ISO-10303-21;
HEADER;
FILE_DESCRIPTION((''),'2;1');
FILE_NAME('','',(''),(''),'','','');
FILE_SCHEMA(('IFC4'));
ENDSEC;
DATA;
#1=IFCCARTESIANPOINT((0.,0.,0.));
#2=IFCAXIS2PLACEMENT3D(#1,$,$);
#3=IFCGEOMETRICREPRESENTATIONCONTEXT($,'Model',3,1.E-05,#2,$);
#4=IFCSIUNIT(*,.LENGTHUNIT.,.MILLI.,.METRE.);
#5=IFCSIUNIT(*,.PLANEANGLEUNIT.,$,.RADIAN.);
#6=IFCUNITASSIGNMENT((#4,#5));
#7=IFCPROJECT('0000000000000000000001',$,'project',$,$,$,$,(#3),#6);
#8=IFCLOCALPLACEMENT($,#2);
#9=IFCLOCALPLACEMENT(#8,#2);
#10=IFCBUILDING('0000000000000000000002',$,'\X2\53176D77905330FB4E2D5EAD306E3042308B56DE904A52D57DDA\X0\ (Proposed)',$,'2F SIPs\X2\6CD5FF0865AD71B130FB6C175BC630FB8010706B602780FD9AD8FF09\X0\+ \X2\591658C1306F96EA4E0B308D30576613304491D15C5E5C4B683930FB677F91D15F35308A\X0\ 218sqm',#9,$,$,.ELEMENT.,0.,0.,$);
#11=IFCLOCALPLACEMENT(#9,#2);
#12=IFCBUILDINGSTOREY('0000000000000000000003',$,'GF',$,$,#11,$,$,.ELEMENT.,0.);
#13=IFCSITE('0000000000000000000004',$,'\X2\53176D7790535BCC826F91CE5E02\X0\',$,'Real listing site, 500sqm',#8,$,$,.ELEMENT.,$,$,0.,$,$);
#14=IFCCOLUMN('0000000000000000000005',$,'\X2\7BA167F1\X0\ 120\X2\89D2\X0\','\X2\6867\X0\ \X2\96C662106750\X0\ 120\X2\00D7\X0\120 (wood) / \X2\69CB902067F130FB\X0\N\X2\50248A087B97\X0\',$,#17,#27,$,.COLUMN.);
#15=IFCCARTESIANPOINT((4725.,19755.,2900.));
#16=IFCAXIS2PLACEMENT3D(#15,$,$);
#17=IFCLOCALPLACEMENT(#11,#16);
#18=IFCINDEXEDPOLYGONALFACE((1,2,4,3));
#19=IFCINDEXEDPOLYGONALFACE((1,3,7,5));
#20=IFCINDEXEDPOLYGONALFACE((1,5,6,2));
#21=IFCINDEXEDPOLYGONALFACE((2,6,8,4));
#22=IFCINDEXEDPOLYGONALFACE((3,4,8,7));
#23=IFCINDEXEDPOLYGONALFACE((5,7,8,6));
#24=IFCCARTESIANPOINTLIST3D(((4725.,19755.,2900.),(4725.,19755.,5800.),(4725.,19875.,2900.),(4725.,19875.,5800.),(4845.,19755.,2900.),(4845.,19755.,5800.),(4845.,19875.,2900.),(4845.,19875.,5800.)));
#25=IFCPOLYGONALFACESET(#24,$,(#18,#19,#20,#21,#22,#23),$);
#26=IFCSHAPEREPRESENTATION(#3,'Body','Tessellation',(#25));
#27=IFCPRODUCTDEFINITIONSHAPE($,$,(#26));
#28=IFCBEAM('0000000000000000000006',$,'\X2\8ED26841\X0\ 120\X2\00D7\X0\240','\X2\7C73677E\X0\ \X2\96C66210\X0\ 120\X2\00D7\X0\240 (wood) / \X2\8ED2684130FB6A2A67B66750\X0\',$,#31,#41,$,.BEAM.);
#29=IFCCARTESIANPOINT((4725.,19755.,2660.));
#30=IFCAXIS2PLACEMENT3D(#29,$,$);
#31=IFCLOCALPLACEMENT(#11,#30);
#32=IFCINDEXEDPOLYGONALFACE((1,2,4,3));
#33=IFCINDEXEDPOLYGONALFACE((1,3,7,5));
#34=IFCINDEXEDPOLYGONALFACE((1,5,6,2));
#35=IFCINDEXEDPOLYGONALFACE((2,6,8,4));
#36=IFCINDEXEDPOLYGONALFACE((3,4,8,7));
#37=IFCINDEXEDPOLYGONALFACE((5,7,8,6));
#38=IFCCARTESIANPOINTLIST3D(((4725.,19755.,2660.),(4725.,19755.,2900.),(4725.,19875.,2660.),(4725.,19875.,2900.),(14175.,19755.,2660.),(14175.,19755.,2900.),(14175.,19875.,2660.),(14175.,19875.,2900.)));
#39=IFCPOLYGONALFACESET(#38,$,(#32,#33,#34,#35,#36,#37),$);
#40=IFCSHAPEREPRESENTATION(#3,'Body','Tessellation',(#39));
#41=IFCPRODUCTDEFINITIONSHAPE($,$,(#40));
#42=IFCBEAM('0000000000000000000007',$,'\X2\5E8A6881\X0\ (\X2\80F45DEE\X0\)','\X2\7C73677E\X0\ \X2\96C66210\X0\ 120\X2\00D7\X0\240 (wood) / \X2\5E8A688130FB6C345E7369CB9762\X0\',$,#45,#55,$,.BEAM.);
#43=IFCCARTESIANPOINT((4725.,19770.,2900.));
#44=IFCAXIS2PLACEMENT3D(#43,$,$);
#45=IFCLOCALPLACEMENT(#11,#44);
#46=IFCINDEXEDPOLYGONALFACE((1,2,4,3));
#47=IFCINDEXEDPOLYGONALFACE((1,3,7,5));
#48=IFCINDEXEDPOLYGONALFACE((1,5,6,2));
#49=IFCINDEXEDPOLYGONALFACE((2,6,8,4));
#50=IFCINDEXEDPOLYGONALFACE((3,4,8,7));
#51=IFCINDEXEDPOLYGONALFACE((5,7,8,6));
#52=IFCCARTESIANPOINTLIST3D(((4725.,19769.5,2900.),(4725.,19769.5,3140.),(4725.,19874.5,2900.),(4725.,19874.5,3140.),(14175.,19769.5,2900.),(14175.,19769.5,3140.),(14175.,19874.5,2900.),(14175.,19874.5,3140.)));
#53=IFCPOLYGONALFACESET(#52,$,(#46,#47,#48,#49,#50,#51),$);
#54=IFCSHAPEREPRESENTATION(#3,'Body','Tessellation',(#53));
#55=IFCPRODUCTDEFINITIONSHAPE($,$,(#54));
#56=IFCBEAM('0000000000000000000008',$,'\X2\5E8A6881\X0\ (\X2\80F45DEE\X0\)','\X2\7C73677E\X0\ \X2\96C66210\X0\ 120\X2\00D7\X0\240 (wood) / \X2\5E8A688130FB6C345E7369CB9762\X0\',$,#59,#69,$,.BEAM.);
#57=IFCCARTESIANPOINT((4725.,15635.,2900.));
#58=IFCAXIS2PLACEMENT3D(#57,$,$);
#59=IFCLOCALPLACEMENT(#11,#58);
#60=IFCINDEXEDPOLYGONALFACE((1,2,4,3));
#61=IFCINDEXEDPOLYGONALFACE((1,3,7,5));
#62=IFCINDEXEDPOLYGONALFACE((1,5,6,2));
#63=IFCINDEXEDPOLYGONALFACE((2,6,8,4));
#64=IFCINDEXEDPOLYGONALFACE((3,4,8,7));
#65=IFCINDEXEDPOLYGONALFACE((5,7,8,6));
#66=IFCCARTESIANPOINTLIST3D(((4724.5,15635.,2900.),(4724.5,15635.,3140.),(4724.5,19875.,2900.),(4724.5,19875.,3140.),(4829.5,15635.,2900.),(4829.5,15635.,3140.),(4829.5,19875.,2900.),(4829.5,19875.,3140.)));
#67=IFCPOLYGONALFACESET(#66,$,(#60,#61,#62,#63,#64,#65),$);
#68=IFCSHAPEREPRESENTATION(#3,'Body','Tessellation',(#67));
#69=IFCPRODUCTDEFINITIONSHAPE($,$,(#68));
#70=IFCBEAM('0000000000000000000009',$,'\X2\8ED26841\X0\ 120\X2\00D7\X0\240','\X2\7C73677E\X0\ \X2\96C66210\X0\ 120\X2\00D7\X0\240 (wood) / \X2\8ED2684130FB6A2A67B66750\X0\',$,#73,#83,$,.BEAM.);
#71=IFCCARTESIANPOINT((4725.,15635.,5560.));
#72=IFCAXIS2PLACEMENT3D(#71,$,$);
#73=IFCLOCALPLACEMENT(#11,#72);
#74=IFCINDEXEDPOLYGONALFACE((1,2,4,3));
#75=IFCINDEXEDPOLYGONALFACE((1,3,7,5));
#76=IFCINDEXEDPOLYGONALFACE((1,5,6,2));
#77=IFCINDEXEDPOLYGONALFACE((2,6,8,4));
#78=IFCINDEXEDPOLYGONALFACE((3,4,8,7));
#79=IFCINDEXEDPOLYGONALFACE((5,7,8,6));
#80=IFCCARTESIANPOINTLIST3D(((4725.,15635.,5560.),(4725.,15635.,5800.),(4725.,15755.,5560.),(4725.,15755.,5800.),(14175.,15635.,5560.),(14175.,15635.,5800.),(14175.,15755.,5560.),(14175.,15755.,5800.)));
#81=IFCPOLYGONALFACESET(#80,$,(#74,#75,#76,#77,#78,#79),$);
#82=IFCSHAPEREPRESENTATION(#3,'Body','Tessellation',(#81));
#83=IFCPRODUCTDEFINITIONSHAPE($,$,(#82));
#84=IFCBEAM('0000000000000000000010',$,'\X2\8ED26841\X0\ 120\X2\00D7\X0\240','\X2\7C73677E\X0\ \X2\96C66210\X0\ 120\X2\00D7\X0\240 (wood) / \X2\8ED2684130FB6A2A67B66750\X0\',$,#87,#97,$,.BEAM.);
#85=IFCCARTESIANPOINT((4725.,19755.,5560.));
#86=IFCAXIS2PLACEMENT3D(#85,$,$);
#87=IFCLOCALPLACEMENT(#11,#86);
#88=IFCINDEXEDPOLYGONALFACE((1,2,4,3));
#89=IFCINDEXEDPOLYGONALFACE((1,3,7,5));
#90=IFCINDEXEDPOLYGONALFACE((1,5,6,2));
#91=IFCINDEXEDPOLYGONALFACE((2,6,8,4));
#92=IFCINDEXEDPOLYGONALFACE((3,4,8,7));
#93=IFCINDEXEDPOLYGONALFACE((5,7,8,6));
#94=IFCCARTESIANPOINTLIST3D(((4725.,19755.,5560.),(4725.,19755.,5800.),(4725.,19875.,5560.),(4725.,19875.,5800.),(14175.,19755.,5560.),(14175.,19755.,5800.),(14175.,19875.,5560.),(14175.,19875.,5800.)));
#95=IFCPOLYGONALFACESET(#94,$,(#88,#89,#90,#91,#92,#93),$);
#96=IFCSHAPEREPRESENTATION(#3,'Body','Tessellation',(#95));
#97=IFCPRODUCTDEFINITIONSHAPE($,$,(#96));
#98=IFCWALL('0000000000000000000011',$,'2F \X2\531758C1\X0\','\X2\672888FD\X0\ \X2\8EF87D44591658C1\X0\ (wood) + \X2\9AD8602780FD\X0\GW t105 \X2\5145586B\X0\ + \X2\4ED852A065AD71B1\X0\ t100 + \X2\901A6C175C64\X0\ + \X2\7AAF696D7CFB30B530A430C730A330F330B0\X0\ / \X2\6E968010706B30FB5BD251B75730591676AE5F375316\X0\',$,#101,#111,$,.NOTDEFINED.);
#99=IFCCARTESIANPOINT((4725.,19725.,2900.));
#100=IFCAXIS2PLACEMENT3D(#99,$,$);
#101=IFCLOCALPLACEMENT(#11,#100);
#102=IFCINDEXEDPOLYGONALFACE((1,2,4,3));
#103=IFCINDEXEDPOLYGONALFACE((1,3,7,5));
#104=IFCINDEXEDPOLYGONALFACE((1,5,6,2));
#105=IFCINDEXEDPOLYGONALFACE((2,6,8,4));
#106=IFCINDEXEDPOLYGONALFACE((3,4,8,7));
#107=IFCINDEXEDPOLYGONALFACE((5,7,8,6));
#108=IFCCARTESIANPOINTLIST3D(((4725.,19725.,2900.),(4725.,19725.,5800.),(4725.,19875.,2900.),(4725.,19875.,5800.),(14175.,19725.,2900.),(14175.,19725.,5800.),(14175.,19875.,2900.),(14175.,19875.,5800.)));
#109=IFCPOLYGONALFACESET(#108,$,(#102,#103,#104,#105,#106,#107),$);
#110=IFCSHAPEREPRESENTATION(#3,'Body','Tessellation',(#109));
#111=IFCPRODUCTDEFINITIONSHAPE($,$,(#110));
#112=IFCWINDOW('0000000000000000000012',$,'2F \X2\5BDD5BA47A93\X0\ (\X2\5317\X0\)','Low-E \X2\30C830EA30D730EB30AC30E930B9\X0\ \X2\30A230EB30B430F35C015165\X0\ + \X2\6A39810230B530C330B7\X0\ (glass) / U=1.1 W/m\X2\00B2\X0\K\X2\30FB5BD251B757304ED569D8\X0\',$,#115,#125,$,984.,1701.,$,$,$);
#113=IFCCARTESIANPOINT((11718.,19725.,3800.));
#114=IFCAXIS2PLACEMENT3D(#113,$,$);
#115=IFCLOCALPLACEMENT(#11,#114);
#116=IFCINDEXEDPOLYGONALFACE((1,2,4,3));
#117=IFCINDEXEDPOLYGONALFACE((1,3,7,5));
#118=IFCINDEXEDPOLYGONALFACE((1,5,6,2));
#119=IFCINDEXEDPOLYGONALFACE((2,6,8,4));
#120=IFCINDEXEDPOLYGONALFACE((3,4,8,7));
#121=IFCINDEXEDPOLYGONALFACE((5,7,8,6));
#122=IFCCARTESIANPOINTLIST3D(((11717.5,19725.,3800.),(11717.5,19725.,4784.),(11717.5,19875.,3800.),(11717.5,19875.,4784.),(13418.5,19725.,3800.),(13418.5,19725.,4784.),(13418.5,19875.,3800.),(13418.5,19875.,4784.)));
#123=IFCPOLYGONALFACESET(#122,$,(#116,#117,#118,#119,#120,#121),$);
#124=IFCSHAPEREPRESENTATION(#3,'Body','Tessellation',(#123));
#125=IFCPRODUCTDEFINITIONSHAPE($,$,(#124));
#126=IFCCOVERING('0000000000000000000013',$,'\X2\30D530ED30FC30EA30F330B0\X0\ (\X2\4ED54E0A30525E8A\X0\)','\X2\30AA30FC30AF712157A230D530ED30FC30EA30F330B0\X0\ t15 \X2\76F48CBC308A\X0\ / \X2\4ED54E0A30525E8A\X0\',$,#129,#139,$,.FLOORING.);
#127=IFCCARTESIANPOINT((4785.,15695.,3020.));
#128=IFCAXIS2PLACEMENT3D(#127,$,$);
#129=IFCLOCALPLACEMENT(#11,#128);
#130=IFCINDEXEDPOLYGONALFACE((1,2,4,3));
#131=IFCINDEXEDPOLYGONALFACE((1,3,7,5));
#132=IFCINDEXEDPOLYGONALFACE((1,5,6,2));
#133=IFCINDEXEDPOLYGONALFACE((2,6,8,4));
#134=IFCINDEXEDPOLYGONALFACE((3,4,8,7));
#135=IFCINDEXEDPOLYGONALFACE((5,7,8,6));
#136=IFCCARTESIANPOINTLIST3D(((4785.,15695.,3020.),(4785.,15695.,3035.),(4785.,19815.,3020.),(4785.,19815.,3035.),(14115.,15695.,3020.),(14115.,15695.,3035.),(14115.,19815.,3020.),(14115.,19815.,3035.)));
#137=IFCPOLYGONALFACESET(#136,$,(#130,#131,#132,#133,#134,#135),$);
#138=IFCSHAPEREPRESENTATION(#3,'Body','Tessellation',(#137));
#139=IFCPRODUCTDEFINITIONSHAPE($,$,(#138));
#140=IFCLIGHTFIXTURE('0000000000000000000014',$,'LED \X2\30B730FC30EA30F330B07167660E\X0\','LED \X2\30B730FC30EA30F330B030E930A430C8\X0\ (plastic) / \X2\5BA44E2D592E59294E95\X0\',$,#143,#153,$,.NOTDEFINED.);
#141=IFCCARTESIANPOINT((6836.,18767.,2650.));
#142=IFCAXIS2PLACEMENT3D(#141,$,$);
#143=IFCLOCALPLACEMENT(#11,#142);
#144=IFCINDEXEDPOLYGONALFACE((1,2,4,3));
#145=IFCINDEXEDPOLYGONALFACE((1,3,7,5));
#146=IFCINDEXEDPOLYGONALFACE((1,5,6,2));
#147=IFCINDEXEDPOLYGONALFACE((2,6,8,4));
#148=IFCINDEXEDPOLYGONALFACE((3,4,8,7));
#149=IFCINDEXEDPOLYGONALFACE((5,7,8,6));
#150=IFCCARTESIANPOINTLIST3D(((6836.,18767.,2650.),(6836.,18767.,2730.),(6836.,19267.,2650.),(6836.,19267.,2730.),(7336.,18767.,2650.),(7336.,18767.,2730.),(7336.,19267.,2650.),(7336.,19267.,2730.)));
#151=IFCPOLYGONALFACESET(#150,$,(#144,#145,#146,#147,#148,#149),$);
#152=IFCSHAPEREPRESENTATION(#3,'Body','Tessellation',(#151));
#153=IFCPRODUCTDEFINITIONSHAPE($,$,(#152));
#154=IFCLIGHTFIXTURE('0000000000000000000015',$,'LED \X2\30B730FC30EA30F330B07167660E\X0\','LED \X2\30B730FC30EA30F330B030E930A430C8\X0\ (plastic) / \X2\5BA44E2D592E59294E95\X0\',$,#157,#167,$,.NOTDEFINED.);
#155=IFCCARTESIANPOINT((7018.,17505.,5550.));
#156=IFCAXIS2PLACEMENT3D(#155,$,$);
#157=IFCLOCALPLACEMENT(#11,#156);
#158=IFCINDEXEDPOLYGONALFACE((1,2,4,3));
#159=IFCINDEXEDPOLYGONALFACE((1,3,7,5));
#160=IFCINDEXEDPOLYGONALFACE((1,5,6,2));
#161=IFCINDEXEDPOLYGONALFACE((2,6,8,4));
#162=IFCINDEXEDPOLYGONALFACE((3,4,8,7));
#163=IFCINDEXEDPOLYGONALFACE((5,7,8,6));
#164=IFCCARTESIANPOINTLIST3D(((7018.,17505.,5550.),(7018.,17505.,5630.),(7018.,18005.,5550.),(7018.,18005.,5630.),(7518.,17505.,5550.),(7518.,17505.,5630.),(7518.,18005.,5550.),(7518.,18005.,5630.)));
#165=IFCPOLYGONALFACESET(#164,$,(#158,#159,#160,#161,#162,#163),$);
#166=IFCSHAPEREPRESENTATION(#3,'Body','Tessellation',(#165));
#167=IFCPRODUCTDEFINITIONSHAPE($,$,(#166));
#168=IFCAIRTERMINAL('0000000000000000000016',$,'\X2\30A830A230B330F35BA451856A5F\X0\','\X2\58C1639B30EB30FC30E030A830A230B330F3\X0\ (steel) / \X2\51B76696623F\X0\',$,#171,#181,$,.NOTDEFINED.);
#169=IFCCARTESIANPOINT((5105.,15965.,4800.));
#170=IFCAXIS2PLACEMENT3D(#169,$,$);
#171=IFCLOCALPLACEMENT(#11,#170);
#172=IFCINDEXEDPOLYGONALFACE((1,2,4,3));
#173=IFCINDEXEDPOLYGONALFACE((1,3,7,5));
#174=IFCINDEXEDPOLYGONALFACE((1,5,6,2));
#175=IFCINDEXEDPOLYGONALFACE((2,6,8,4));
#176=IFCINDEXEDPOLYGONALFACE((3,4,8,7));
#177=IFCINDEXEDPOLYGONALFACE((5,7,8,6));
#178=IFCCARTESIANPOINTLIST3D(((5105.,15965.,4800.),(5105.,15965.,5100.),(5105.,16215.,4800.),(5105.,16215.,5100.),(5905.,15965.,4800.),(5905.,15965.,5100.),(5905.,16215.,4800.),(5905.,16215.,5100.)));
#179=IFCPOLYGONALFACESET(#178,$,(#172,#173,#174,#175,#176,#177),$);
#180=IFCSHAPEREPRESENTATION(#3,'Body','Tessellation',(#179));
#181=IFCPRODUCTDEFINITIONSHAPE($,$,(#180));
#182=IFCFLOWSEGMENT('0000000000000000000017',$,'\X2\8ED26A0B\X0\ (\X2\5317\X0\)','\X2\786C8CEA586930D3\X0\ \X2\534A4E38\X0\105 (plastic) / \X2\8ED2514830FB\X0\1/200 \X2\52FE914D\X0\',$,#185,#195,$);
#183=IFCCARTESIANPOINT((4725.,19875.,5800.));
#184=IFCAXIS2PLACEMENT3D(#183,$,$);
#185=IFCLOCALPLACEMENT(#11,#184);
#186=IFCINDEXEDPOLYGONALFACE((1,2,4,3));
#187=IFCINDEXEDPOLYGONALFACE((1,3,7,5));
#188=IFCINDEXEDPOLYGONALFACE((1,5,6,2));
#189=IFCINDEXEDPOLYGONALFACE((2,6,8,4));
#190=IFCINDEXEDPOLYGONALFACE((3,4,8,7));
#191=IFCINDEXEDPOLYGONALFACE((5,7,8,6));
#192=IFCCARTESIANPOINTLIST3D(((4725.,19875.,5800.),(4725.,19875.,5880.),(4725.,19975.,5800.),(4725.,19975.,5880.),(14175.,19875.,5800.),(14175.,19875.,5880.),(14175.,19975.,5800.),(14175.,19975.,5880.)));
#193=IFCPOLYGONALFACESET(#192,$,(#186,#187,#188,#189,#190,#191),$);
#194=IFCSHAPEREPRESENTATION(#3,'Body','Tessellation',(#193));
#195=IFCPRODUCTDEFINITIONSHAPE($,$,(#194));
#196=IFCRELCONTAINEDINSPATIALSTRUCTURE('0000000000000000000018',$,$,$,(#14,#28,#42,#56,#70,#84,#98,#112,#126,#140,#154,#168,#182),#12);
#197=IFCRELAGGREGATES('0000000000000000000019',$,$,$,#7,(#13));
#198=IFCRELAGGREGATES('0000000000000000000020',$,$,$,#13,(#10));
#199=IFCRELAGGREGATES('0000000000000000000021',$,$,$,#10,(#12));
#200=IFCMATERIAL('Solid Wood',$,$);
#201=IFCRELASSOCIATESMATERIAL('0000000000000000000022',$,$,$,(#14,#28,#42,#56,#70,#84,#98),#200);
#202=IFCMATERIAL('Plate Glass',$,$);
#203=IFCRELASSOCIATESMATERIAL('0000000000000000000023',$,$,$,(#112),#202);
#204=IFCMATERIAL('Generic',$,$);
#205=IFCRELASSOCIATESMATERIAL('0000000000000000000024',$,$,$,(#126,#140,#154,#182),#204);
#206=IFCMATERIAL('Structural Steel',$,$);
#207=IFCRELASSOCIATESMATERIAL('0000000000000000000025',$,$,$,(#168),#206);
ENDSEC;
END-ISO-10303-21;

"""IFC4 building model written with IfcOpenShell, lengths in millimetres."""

from ifc_helpers import new_model, si_unit, frame, frame_2d, origin, place, context, project, spatial, rectangle, extrude, material, element, fill, save


model = new_model("IFC4")

# Units and contexts
model_context = context("Model", 3, precision=1e-05, world=origin())
ifc_project = project(units=[si_unit("LENGTHUNIT", "METRE", prefix="MILLI"), si_unit("PLANEANGLEUNIT", "RADIAN")], contexts=[model_context])

# Site, building, storey
site_placement = place(None, origin())
site = spatial("IfcSite", under=ifc_project, at=site_placement, Name="北海道富良野市", ObjectType="Real listing site, 500sqm", CompositionType="ELEMENT", RefElevation=0.0)
building_placement = place(site_placement, origin())
building = spatial("IfcBuilding", under=site, at=building_placement, Name="北海道・中庭のある回遊動線 (Proposed)", ObjectType="2F SIPs法（断熱・気密・耐火性能高）+ 外壁は雪下ろし易い金属屋根・板金張り 218sqm", CompositionType="ELEMENT", ElevationOfRefHeight=0.0, ElevationOfTerrain=0.0)
storey_placement = place(building_placement, origin())
storey = spatial("IfcBuildingStorey", under=building, at=storey_placement, Name="GF", CompositionType="ELEMENT", Elevation=0.0)

# Column
ifc_material_1 = material(Name="Solid Wood")
column_1_placement = place(storey_placement, frame((4725.0, 19755.0, 2900.0)))
element("IfcColumn", 1, at=column_1_placement, inside=storey, material=ifc_material_1, Name="管柱 120角", Description="桧 集成材 120×120 (wood) / 構造柱・N値計算", PredefinedType="COLUMN", context=model_context, shape_type="SweptSolid", body=[
    extrude(rectangle(XDim=120.0, YDim=120.0, at=frame_2d((60.0, 60.0))), frame((4725.0, 19755.0, 2900.0)), (0.0, 0.0, 1.0), 2900.0),
])

# Beams
beam_1_placement = place(storey_placement, frame((4725.0, 19755.0, 2660.0)))
element("IfcBeam", 2, at=beam_1_placement, inside=storey, material=ifc_material_1, Name="軒桁 120×240", Description="米松 集成 120×240 (wood) / 軒桁・横架材", PredefinedType="BEAM", context=model_context, shape_type="SweptSolid", body=[
    extrude(rectangle(XDim=9450.0, YDim=120.0, at=frame_2d((4725.0, 60.0))), frame((4725.0, 19755.0, 2660.0)), (0.0, 0.0, 1.0), 240.0),
])
beam_2_placement = place(storey_placement, frame((4725.0, 19770.0, 2900.0)))
element("IfcBeam", 3, at=beam_2_placement, inside=storey, material=ifc_material_1, Name="床梁 (胴差)", Description="米松 集成 120×240 (wood) / 床梁・水平構面", PredefinedType="BEAM", context=model_context, shape_type="SweptSolid", body=[
    extrude(rectangle(XDim=9450.0, YDim=105.0, at=frame_2d((4725.0, 52.0))), frame((4725.0, 19770.0, 2900.0)), (0.0, 0.0, 1.0), 240.0),
])
beam_3_placement = place(storey_placement, frame((4725.0, 15635.0, 2900.0)))
element("IfcBeam", 4, at=beam_3_placement, inside=storey, material=ifc_material_1, Name="床梁 (胴差)", Description="米松 集成 120×240 (wood) / 床梁・水平構面", PredefinedType="BEAM", context=model_context, shape_type="SweptSolid", body=[
    extrude(rectangle(XDim=105.0, YDim=4240.0, at=frame_2d((52.0, 2120.0))), frame((4725.0, 15635.0, 2900.0)), (0.0, 0.0, 1.0), 240.0),
])
beam_4_placement = place(storey_placement, frame((4725.0, 15635.0, 5560.0)))
element("IfcBeam", 5, at=beam_4_placement, inside=storey, material=ifc_material_1, Name="軒桁 120×240", Description="米松 集成 120×240 (wood) / 軒桁・横架材", PredefinedType="BEAM", context=model_context, shape_type="SweptSolid", body=[
    extrude(rectangle(XDim=9450.0, YDim=120.0, at=frame_2d((4725.0, 60.0))), frame((4725.0, 15635.0, 5560.0)), (0.0, 0.0, 1.0), 240.0),
])
beam_5_placement = place(storey_placement, frame((4725.0, 19755.0, 5560.0)))
element("IfcBeam", 6, at=beam_5_placement, inside=storey, material=ifc_material_1, Name="軒桁 120×240", Description="米松 集成 120×240 (wood) / 軒桁・横架材", PredefinedType="BEAM", context=model_context, shape_type="SweptSolid", body=[
    extrude(rectangle(XDim=9450.0, YDim=120.0, at=frame_2d((4725.0, 60.0))), frame((4725.0, 19755.0, 5560.0)), (0.0, 0.0, 1.0), 240.0),
])

# Wall, opening, window
wall_placement = place(storey_placement, frame((4725.0, 19725.0, 2900.0)))
wall = element("IfcWall", 7, at=wall_placement, inside=storey, material=ifc_material_1, Name="2F 北壁", Description="木製 軸組外壁 (wood) + 高性能GW t105 充填 + 付加断熱 t100 + 通気層 + 窯業系サイディング / 準耐火・寒冷地外皮強化", PredefinedType="NOTDEFINED", context=model_context, shape_type="SweptSolid", body=[
    extrude(rectangle(XDim=9450.0, YDim=150.0, at=frame_2d((4725.0, 75.0))), frame((4725.0, 19725.0, 2900.0)), (0.0, 0.0, 1.0), 2900.0),
])
opening_placement = place(storey_placement, frame((11718.0, 19725.0, 3800.0)))
opening = element("IfcOpeningElement", 8, at=opening_placement, cuts=wall, PredefinedType="NOTDEFINED", context=model_context, shape_type="SweptSolid", body=[
    extrude(rectangle(XDim=1701.0, YDim=150.0, at=frame_2d((850.0, 75.0))), frame((11718.0, 19725.0, 3800.0)), (0.0, 0.0, 1.0), 984.0),
])
ifc_material_2 = material(Name="Plate Glass")
window_placement = place(storey_placement, frame((11718.0, 19725.0, 3800.0)))
window = element("IfcWindow", 9, at=window_placement, inside=storey, material=ifc_material_2, Name="2F 寝室窓 (北)", Description="Low-E トリプルガラス アルゴン封入 + 樹脂サッシ (glass) / U=1.1 W/m²K・寒冷地仕様", OverallHeight=984.0, OverallWidth=1701.0, context=model_context, shape_type="SweptSolid", body=[
    extrude(rectangle(XDim=1701.0, YDim=150.0, at=frame_2d((850.0, 75.0))), frame((11718.0, 19725.0, 3800.0)), (0.0, 0.0, 1.0), 984.0),
])
fill(opening, window)

# Covering
ifc_material_3 = material(Name="Generic")
covering_placement = place(storey_placement, frame((4785.0, 15695.0, 3020.0)))
element("IfcCovering", 10, at=covering_placement, inside=storey, material=ifc_material_3, Name="フローリング (仕上げ床)", Description="オーク無垢フローリング t15 直貼り / 仕上げ床", PredefinedType="FLOORING", context=model_context, shape_type="SweptSolid", body=[
    extrude(rectangle(XDim=9330.0, YDim=4120.0, at=frame_2d((4665.0, 2060.0))), frame((4785.0, 15695.0, 3020.0)), (0.0, 0.0, 1.0), 15.0),
])

# Light fixtures
light_fixture_1_placement = place(storey_placement, frame((6836.0, 18767.0, 2650.0)))
element("IfcLightFixture", 11, at=light_fixture_1_placement, inside=storey, material=ifc_material_3, Name="LED シーリング照明", Description="LED シーリングライト (plastic) / 室中央天井", PredefinedType="NOTDEFINED", context=model_context, shape_type="SweptSolid", body=[
    extrude(rectangle(XDim=500.0, YDim=500.0, at=frame_2d((250.0, 250.0))), frame((6836.0, 18767.0, 2650.0)), (0.0, 0.0, 1.0), 80.0),
])
light_fixture_2_placement = place(storey_placement, frame((7018.0, 17505.0, 5550.0)))
element("IfcLightFixture", 12, at=light_fixture_2_placement, inside=storey, material=ifc_material_3, Name="LED シーリング照明", Description="LED シーリングライト (plastic) / 室中央天井", PredefinedType="NOTDEFINED", context=model_context, shape_type="SweptSolid", body=[
    extrude(rectangle(XDim=500.0, YDim=500.0, at=frame_2d((250.0, 250.0))), frame((7018.0, 17505.0, 5550.0)), (0.0, 0.0, 1.0), 80.0),
])

# Air terminal
ifc_material_4 = material(Name="Structural Steel")
air_terminal_placement = place(storey_placement, frame((5105.0, 15965.0, 4800.0)))
element("IfcAirTerminal", 13, at=air_terminal_placement, inside=storey, material=ifc_material_4, Name="エアコン室内機", Description="壁掛ルームエアコン (steel) / 冷暖房", PredefinedType="NOTDEFINED", context=model_context, shape_type="SweptSolid", body=[
    extrude(rectangle(XDim=800.0, YDim=250.0, at=frame_2d((400.0, 125.0))), frame((5105.0, 15965.0, 4800.0)), (0.0, 0.0, 1.0), 300.0),
])

# Flow segment
flow_segment_placement = place(storey_placement, frame((4725.0, 19875.0, 5800.0)))
element("IfcFlowSegment", 14, at=flow_segment_placement, inside=storey, material=ifc_material_3, Name="軒樋 (北)", Description="硬質塩ビ 半丸105 (plastic) / 軒先・1/200 勾配", context=model_context, shape_type="SweptSolid", body=[
    extrude(rectangle(XDim=9450.0, YDim=100.0, at=frame_2d((4725.0, 50.0))), frame((4725.0, 19875.0, 5800.0)), (0.0, 0.0, 1.0), 80.0),
])

save(model, "model.ifc")
